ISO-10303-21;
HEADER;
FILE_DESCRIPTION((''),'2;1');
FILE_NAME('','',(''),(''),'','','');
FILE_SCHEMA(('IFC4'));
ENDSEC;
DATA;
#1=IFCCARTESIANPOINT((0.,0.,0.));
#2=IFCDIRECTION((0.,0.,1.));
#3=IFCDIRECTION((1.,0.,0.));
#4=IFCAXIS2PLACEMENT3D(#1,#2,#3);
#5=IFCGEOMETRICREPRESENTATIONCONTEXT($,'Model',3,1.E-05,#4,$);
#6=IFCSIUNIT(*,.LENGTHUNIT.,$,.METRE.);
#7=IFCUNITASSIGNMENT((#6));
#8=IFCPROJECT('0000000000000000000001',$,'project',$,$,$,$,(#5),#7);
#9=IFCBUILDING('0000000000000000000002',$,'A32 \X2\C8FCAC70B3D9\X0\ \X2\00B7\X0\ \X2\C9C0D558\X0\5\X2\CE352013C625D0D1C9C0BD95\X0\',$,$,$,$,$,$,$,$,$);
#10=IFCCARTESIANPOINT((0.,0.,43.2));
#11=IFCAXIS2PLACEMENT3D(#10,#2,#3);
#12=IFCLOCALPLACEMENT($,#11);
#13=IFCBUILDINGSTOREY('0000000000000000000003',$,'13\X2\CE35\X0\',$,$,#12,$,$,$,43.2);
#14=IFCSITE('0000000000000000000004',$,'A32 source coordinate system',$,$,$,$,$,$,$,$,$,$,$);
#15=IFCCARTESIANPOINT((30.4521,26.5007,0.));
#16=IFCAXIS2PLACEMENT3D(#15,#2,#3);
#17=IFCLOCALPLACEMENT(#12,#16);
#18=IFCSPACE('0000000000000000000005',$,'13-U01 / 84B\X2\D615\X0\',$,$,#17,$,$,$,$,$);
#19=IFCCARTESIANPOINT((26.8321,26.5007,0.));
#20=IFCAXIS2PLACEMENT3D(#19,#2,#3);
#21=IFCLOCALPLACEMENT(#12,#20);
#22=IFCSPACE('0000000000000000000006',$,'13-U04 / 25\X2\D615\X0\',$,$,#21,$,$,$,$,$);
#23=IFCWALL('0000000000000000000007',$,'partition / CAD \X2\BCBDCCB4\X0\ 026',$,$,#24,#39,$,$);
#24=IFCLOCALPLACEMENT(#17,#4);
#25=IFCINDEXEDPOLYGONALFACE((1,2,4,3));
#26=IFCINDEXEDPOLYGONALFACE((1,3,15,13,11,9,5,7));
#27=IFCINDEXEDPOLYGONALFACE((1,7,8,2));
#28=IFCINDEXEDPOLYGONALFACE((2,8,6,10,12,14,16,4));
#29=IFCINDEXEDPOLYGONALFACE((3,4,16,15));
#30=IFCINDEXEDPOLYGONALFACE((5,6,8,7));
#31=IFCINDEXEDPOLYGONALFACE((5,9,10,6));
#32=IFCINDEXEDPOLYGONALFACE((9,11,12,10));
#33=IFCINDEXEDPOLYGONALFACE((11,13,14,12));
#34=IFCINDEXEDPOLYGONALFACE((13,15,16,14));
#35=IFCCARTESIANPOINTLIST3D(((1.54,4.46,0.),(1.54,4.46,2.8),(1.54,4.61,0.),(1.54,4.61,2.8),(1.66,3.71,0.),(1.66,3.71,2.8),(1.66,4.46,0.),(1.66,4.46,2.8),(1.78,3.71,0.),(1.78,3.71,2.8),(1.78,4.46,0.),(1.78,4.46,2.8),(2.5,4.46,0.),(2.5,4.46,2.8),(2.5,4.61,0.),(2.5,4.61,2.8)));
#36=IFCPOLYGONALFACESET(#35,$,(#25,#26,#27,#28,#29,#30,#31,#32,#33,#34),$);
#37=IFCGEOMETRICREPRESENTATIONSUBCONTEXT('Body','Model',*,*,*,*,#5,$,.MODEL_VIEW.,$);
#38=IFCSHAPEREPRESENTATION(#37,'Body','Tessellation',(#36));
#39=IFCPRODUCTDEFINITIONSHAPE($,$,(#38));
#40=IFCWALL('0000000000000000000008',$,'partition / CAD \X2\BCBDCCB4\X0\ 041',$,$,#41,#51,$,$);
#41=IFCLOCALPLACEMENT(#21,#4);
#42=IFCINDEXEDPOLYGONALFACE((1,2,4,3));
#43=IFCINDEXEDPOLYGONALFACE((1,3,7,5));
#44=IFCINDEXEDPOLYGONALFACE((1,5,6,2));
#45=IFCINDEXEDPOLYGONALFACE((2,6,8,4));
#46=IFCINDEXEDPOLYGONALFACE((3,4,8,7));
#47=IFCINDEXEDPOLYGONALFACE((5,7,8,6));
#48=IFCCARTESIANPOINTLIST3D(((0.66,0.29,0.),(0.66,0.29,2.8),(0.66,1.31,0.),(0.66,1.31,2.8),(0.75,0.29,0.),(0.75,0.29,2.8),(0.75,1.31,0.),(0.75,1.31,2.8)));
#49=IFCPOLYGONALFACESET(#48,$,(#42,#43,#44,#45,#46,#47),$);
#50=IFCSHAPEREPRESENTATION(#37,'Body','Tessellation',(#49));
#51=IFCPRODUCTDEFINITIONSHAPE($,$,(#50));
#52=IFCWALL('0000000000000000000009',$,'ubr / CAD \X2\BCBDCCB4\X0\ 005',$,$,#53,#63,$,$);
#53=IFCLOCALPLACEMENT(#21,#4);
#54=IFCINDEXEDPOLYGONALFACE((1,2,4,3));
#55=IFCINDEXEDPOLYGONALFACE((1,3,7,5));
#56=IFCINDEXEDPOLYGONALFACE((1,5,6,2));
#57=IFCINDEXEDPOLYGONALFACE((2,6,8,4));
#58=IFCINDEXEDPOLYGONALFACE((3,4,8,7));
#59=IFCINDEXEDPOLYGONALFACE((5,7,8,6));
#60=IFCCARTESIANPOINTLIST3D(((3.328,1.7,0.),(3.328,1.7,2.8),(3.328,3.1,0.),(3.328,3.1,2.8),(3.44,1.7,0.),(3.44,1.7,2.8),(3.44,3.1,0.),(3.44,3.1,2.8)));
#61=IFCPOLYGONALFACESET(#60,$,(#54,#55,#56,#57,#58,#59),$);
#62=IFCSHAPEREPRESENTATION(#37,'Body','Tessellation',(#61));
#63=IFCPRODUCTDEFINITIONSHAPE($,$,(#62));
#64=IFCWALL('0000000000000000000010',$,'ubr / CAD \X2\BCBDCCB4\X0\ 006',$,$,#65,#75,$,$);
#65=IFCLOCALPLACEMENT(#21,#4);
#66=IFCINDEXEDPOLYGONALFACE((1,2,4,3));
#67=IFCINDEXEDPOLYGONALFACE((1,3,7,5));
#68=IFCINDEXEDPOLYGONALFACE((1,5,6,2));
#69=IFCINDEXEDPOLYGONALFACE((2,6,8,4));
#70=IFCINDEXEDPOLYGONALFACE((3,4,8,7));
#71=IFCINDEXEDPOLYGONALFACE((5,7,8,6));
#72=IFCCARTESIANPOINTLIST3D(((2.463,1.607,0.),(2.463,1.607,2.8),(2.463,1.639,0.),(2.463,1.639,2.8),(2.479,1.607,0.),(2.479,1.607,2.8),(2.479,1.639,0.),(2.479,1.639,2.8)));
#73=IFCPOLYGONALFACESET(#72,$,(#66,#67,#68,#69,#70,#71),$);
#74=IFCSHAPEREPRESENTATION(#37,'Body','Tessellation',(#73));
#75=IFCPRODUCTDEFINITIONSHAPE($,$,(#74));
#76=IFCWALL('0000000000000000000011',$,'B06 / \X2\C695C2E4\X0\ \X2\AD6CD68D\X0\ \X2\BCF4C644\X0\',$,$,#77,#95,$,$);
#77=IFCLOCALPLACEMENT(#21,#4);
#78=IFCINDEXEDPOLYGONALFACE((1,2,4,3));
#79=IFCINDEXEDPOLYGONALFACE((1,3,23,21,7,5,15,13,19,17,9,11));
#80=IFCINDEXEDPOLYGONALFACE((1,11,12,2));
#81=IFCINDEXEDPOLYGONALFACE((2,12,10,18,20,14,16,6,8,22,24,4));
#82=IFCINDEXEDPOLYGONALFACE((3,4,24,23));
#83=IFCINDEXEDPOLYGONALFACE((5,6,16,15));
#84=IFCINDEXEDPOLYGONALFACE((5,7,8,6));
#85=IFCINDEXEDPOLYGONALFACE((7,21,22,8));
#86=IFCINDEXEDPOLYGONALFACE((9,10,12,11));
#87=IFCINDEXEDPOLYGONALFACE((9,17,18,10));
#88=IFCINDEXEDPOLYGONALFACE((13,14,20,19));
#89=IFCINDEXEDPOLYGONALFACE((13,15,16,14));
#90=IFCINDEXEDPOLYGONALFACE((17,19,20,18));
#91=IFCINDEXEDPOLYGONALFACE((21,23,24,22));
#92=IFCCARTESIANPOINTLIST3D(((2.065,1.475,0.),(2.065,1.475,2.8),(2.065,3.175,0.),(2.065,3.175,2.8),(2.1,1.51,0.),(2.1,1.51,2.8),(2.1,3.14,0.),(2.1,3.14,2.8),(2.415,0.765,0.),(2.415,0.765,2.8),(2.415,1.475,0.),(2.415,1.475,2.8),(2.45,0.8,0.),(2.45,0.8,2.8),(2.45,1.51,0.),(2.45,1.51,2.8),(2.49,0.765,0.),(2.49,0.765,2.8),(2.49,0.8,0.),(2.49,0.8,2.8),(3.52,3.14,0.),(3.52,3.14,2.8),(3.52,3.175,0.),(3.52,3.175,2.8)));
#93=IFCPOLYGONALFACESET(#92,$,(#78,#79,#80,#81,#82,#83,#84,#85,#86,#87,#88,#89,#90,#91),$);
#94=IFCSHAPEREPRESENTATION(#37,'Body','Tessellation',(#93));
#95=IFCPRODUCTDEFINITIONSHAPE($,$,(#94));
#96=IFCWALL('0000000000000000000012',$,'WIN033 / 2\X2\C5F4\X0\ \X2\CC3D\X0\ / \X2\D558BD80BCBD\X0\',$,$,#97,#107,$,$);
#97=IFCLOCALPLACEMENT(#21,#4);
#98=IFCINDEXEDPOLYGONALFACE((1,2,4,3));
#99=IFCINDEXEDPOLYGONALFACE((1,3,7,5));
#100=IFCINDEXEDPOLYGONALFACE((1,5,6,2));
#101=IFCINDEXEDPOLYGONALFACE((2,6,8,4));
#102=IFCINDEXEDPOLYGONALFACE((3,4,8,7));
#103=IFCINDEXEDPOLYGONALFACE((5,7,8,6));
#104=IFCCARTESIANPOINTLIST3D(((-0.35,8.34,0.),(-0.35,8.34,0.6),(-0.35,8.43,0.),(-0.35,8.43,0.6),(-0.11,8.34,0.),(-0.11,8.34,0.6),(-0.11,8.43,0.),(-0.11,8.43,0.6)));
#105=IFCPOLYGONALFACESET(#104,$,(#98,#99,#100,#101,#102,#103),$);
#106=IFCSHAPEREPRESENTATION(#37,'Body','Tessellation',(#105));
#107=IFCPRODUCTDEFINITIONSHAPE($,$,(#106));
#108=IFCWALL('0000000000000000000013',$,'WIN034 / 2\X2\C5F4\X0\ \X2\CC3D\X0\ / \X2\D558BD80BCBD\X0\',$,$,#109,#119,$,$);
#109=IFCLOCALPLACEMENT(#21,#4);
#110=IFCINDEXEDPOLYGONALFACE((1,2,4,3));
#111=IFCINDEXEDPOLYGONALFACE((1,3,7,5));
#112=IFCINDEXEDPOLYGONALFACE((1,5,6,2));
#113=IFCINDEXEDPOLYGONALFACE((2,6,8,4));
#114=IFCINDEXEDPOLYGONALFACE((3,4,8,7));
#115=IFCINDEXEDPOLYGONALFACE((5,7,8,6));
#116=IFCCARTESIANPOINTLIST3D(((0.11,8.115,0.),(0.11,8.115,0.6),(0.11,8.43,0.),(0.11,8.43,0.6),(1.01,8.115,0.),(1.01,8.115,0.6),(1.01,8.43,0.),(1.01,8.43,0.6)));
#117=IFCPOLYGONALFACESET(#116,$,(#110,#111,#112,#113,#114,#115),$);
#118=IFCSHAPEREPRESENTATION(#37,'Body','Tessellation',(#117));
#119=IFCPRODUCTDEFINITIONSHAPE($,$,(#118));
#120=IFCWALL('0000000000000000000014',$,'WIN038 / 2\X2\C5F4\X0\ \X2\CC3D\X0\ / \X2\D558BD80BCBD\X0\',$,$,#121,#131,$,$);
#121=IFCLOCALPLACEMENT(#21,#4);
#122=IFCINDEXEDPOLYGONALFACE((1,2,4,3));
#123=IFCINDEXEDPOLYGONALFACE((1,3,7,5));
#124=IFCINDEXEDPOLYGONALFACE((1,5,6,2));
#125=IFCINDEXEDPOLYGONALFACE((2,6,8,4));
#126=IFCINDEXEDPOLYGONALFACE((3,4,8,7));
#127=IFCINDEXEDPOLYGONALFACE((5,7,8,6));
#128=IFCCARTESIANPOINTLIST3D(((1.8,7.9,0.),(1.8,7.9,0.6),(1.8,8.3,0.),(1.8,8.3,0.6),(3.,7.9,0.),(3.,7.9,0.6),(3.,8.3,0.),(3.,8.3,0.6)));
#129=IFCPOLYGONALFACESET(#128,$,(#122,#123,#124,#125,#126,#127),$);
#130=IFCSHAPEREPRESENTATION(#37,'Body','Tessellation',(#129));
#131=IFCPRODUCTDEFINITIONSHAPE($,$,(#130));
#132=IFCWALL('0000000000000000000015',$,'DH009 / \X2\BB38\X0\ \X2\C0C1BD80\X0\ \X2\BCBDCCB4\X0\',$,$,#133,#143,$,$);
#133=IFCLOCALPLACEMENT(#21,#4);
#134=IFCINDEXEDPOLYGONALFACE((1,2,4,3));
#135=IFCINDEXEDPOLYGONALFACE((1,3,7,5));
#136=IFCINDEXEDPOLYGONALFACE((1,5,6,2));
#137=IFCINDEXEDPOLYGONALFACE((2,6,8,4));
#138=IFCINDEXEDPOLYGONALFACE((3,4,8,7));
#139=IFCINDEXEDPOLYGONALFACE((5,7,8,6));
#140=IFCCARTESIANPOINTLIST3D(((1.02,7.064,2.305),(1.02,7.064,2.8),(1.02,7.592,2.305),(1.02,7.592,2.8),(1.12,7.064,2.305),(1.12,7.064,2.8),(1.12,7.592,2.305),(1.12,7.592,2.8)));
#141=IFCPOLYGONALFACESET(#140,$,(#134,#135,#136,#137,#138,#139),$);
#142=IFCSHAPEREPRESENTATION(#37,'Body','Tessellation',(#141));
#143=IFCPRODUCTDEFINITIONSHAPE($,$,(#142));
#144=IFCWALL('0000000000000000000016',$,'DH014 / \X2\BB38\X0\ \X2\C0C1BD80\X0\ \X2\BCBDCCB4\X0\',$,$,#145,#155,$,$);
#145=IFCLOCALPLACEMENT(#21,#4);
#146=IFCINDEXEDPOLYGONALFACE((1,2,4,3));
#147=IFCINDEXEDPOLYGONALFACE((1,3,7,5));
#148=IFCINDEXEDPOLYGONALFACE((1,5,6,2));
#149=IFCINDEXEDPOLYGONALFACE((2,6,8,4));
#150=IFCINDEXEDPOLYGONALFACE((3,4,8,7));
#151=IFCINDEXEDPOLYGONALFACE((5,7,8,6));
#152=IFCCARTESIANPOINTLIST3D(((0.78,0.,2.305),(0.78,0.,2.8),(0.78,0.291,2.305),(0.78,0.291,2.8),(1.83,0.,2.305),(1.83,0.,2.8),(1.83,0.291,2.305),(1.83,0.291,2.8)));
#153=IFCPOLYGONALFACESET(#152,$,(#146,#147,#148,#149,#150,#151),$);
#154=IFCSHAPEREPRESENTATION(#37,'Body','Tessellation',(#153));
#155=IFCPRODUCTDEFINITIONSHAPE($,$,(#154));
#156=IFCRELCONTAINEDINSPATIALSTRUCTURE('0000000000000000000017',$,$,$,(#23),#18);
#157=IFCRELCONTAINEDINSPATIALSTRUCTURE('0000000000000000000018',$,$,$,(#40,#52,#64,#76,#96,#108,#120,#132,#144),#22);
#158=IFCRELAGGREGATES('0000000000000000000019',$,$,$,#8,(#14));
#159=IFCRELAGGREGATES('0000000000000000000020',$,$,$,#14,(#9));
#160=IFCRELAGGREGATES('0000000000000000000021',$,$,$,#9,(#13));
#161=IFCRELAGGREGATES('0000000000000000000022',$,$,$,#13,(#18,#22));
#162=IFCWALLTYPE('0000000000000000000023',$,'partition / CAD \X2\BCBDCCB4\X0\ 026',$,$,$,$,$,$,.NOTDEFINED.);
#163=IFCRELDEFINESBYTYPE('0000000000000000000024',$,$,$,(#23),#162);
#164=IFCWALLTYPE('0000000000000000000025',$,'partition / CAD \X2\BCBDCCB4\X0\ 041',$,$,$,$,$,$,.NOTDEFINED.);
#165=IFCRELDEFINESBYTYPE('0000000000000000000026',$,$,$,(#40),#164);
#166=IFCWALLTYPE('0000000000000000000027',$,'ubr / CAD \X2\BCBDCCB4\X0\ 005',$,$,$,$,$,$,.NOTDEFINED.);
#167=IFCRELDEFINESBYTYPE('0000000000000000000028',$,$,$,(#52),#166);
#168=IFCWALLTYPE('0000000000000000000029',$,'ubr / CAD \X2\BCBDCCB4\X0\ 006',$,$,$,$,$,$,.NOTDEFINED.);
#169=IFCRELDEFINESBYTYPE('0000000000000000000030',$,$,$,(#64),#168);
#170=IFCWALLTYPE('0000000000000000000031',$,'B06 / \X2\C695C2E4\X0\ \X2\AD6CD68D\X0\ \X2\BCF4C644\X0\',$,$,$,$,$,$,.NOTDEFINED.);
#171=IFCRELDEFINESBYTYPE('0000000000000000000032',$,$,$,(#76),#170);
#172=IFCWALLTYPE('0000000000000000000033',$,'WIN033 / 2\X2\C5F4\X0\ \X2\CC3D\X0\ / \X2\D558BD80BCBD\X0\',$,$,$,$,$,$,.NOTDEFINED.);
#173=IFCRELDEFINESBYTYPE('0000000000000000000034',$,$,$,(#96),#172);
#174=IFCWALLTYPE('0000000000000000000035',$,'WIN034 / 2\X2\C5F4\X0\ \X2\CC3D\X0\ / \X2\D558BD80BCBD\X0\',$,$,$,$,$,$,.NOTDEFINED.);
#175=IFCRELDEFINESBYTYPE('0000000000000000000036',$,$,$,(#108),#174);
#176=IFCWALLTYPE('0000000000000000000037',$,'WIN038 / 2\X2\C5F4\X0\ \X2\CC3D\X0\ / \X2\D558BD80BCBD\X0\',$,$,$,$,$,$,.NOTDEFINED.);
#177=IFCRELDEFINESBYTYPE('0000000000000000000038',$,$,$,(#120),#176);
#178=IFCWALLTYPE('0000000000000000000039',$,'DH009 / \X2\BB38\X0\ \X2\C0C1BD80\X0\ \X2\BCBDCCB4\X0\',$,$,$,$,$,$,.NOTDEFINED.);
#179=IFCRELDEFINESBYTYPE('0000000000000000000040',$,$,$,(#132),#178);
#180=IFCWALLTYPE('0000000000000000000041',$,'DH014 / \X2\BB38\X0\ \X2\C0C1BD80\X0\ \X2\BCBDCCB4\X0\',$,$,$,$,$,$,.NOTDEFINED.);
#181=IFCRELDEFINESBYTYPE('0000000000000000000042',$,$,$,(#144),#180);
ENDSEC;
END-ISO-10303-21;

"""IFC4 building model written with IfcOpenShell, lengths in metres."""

from ifc_helpers import new_model, si_unit, frame, origin, origin_with_axes, place, context, subcontext, project, spatial, polyline, outline, extrude, source, transform, mapped, type_object, type_shapes, element, save


model = new_model("IFC4")

# Units and contexts
model_context = context("Model", 3, precision=1e-05, world=origin_with_axes())
body_context = subcontext(model_context, "Body", "Model", "MODEL_VIEW")
ifc_project = project(units=[si_unit("LENGTHUNIT", "METRE")], contexts=[model_context])

# Site, building, storey, space
site = spatial("IfcSite", under=ifc_project, Name="A32 source coordinate system")
building = spatial("IfcBuilding", under=site, Name="A32 주거동 · 지하5층–옥탑지붕")
storey_placement = place(None, frame((0.0, 0.0, 43.2), z_axis=(0.0, 0.0, 1.0), x_axis=(1.0, 0.0, 0.0)))
storey = spatial("IfcBuildingStorey", under=building, at=storey_placement, Name="13층", Elevation=43.2)
space_1_placement = place(storey_placement, frame((30.4521, 26.5007, 0.0), z_axis=(0.0, 0.0, 1.0), x_axis=(1.0, 0.0, 0.0)))
space_1 = spatial("IfcSpace", under=storey, at=space_1_placement, Name="13-U01 / 84B형")

# Wall
wall_type_1 = type_object("IfcWallType", Name="partition / CAD 벽체 026", PredefinedType="NOTDEFINED")
shared_shape_1 = source(origin(), body_context, "Body", "SweptSolid", [
    extrude(outline(polyline([(1.54, 4.46), (1.54, 4.61), (2.5, 4.61), (2.5, 4.46), (1.78, 4.46), (1.78, 3.71), (1.66, 3.71), (1.66, 4.46), (1.54, 4.46)])), origin(), (0.0, 0.0, 1.0), 2.8),
])
type_shapes(wall_type_1, [shared_shape_1])
wall_1_placement = place(space_1_placement, origin_with_axes())
element("IfcWall", 1, at=wall_1_placement, inside=space_1, type_object=wall_type_1, Name="partition / CAD 벽체 026", context=body_context, shape_type="MappedRepresentation", body=[
    mapped(shared_shape_1, transform((0.0, 0.0, 0.0), scale=1.0)),
])

# Shared definitions
space_2_placement = place(storey_placement, frame((26.8321, 26.5007, 0.0), z_axis=(0.0, 0.0, 1.0), x_axis=(1.0, 0.0, 0.0)))
space_2 = spatial("IfcSpace", under=storey, at=space_2_placement, Name="13-U04 / 25형")

# Walls
wall_type_2 = type_object("IfcWallType", Name="partition / CAD 벽체 041", PredefinedType="NOTDEFINED")
shared_shape_2 = source(origin(), body_context, "Body", "SweptSolid", [
    extrude(outline(polyline([(0.75, 1.31), (0.75, 0.29), (0.66, 0.29), (0.66, 1.31), (0.75, 1.31)])), origin(), (0.0, 0.0, 1.0), 2.8),
])
type_shapes(wall_type_2, [shared_shape_2])
wall_2_placement = place(space_2_placement, origin_with_axes())
element("IfcWall", 2, at=wall_2_placement, inside=space_2, type_object=wall_type_2, Name="partition / CAD 벽체 041", context=body_context, shape_type="MappedRepresentation", body=[
    mapped(shared_shape_2, transform((0.0, 0.0, 0.0), scale=1.0)),
])
wall_type_3 = type_object("IfcWallType", Name="ubr / CAD 벽체 005", PredefinedType="NOTDEFINED")
shared_shape_3 = source(origin(), body_context, "Body", "SweptSolid", [
    extrude(outline(polyline([(3.44, 3.1), (3.44, 1.7), (3.328, 1.7), (3.328, 3.1), (3.44, 3.1)])), origin(), (0.0, 0.0, 1.0), 2.8),
])
type_shapes(wall_type_3, [shared_shape_3])
wall_3_placement = place(space_2_placement, origin_with_axes())
element("IfcWall", 3, at=wall_3_placement, inside=space_2, type_object=wall_type_3, Name="ubr / CAD 벽체 005", context=body_context, shape_type="MappedRepresentation", body=[
    mapped(shared_shape_3, transform((0.0, 0.0, 0.0), scale=1.0)),
])
wall_type_4 = type_object("IfcWallType", Name="ubr / CAD 벽체 006", PredefinedType="NOTDEFINED")
shared_shape_4 = source(origin(), body_context, "Body", "SweptSolid", [
    extrude(outline(polyline([(2.463, 1.639), (2.479, 1.639), (2.479, 1.607), (2.463, 1.607), (2.463, 1.639)])), origin(), (0.0, 0.0, 1.0), 2.8),
])
type_shapes(wall_type_4, [shared_shape_4])
wall_4_placement = place(space_2_placement, origin_with_axes())
element("IfcWall", 4, at=wall_4_placement, inside=space_2, type_object=wall_type_4, Name="ubr / CAD 벽체 006", context=body_context, shape_type="MappedRepresentation", body=[
    mapped(shared_shape_4, transform((0.0, 0.0, 0.0), scale=1.0)),
])
wall_type_5 = type_object("IfcWallType", Name="B06 / 욕실 구획 보완", PredefinedType="NOTDEFINED")
shared_shape_5 = source(origin(), body_context, "Body", "SweptSolid", [
    extrude(outline(polyline([(3.52, 3.14), (2.1, 3.14), (2.1, 1.51), (2.45, 1.51), (2.45, 0.8), (2.49, 0.8), (2.49, 0.765), (2.415, 0.765), (2.415, 1.475), (2.065, 1.475), (2.065, 3.175), (3.52, 3.175), (3.52, 3.14)])), origin(), (0.0, 0.0, 1.0), 2.8),
])
type_shapes(wall_type_5, [shared_shape_5])
wall_5_placement = place(space_2_placement, origin_with_axes())
element("IfcWall", 5, at=wall_5_placement, inside=space_2, type_object=wall_type_5, Name="B06 / 욕실 구획 보완", context=body_context, shape_type="MappedRepresentation", body=[
    mapped(shared_shape_5, transform((0.0, 0.0, 0.0), scale=1.0)),
])
wall_type_6 = type_object("IfcWallType", Name="WIN033 / 2열 창 / 하부벽", PredefinedType="NOTDEFINED")
shared_shape_6 = source(origin(), body_context, "Body", "SweptSolid", [
    extrude(outline(polyline([(-0.11, 8.43), (-0.11, 8.34), (-0.35, 8.34), (-0.35, 8.43), (-0.11, 8.43)])), origin(), (0.0, 0.0, 1.0), 0.6),
])
type_shapes(wall_type_6, [shared_shape_6])
wall_6_placement = place(space_2_placement, origin_with_axes())
element("IfcWall", 6, at=wall_6_placement, inside=space_2, type_object=wall_type_6, Name="WIN033 / 2열 창 / 하부벽", context=body_context, shape_type="MappedRepresentation", body=[
    mapped(shared_shape_6, transform((0.0, 0.0, 0.0), scale=1.0)),
])
wall_type_7 = type_object("IfcWallType", Name="WIN034 / 2열 창 / 하부벽", PredefinedType="NOTDEFINED")
shared_shape_7 = source(origin(), body_context, "Body", "SweptSolid", [
    extrude(outline(polyline([(0.11, 8.115), (0.11, 8.43), (1.01, 8.43), (1.01, 8.115), (0.11, 8.115)])), origin(), (0.0, 0.0, 1.0), 0.6),
])
type_shapes(wall_type_7, [shared_shape_7])
wall_7_placement = place(space_2_placement, origin_with_axes())
element("IfcWall", 7, at=wall_7_placement, inside=space_2, type_object=wall_type_7, Name="WIN034 / 2열 창 / 하부벽", context=body_context, shape_type="MappedRepresentation", body=[
    mapped(shared_shape_7, transform((0.0, 0.0, 0.0), scale=1.0)),
])
wall_type_8 = type_object("IfcWallType", Name="WIN038 / 2열 창 / 하부벽", PredefinedType="NOTDEFINED")
shared_shape_8 = source(origin(), body_context, "Body", "SweptSolid", [
    extrude(outline(polyline([(1.8, 7.9), (1.8, 8.3), (3.0, 8.3), (3.0, 7.9), (1.8, 7.9)])), origin(), (0.0, 0.0, 1.0), 0.6),
])
type_shapes(wall_type_8, [shared_shape_8])
wall_8_placement = place(space_2_placement, origin_with_axes())
element("IfcWall", 8, at=wall_8_placement, inside=space_2, type_object=wall_type_8, Name="WIN038 / 2열 창 / 하부벽", context=body_context, shape_type="MappedRepresentation", body=[
    mapped(shared_shape_8, transform((0.0, 0.0, 0.0), scale=1.0)),
])
wall_type_9 = type_object("IfcWallType", Name="DH009 / 문 상부 벽체", PredefinedType="NOTDEFINED")
shared_shape_9 = source(origin(), body_context, "Body", "SweptSolid", [
    extrude(outline(polyline([(1.02, 7.064), (1.02, 7.592), (1.12, 7.592), (1.12, 7.064), (1.02, 7.064)])), frame((0.0, 0.0, 2.305)), (0.0, 0.0, 1.0), 0.495),
])
type_shapes(wall_type_9, [shared_shape_9])
wall_9_placement = place(space_2_placement, origin_with_axes())
element("IfcWall", 9, at=wall_9_placement, inside=space_2, type_object=wall_type_9, Name="DH009 / 문 상부 벽체", context=body_context, shape_type="MappedRepresentation", body=[
    mapped(shared_shape_9, transform((0.0, 0.0, 0.0), scale=1.0)),
])
wall_type_10 = type_object("IfcWallType", Name="DH014 / 문 상부 벽체", PredefinedType="NOTDEFINED")
shared_shape_10 = source(origin(), body_context, "Body", "SweptSolid", [
    extrude(outline(polyline([(0.78, 0.291), (1.83, 0.291), (1.83, 0.0), (0.78, 0.0), (0.78, 0.291)])), frame((0.0, 0.0, 2.305)), (0.0, 0.0, 1.0), 0.495),
])
type_shapes(wall_type_10, [shared_shape_10])
wall_10_placement = place(space_2_placement, origin_with_axes())
element("IfcWall", 10, at=wall_10_placement, inside=space_2, type_object=wall_type_10, Name="DH014 / 문 상부 벽체", context=body_context, shape_type="MappedRepresentation", body=[
    mapped(shared_shape_10, transform((0.0, 0.0, 0.0), scale=1.0)),
])

save(model, "model.ifc")
